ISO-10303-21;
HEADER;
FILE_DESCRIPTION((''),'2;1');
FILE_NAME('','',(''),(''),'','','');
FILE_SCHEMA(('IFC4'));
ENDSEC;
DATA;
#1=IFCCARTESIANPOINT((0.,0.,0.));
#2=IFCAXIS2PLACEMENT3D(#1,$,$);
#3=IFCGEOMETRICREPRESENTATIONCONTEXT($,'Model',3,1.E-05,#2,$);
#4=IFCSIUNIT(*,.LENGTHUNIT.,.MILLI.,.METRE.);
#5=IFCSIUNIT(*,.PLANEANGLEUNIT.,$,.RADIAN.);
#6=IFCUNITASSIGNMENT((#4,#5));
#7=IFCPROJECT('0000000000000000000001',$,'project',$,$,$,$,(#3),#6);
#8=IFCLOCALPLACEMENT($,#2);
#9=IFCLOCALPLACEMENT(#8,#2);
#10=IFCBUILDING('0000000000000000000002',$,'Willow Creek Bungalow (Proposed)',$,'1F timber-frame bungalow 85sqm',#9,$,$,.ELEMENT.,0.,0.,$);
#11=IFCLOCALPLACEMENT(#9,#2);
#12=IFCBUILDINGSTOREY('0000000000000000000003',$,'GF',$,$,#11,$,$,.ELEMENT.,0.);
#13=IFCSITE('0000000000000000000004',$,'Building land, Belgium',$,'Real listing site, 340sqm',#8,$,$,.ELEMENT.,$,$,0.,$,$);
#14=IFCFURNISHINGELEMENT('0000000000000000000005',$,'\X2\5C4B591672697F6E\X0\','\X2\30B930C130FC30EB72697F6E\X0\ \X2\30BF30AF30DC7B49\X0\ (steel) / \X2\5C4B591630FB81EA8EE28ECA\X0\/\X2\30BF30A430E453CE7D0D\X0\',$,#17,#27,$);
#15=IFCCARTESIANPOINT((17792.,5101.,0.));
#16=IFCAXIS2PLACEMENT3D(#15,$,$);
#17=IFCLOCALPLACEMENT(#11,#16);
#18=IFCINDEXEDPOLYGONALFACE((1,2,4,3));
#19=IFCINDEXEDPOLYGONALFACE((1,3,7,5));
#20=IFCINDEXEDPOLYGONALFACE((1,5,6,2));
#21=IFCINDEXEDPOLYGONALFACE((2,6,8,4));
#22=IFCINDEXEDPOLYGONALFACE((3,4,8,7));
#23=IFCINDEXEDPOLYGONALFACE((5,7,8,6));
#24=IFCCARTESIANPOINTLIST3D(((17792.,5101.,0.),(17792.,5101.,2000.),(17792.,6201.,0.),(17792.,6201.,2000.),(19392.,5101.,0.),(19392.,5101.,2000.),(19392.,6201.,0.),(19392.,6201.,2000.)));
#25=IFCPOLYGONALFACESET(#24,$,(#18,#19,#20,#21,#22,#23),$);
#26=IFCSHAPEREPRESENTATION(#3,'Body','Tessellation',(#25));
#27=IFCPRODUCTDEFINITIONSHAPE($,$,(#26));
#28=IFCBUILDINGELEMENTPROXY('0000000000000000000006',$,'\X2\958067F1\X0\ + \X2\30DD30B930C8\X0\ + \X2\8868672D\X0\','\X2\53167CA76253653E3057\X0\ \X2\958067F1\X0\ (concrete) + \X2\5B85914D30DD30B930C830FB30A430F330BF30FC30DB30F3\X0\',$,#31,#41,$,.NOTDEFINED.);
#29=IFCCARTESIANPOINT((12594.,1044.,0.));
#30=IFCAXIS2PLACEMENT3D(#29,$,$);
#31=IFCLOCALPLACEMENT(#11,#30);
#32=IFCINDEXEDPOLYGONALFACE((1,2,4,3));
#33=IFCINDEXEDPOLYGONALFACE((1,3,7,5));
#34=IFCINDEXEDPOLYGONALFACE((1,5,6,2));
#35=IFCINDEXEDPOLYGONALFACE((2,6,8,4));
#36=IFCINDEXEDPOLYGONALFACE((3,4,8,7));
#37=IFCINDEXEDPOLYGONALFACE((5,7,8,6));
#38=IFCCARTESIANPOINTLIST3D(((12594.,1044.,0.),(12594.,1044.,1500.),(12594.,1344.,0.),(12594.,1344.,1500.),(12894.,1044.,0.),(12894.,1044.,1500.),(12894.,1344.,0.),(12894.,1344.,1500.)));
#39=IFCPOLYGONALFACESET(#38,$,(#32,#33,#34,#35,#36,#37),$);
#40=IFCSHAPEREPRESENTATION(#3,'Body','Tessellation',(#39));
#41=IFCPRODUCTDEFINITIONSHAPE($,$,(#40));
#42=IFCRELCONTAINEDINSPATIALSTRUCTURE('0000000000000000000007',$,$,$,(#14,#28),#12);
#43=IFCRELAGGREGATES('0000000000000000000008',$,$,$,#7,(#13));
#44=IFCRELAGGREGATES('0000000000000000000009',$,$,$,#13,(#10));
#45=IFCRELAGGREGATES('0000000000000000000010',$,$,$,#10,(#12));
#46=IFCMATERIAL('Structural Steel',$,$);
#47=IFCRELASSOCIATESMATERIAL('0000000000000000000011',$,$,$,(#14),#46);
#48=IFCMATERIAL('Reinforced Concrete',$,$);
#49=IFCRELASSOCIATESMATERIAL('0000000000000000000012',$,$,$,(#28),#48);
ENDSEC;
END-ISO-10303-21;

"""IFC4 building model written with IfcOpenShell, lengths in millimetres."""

from ifc_helpers import new_model, si_unit, frame, frame_2d, origin, place, context, project, spatial, rectangle, extrude, material, element, save


model = new_model("IFC4")

# Units and contexts
model_context = context("Model", 3, precision=1e-05, world=origin())
ifc_project = project(units=[si_unit("LENGTHUNIT", "METRE", prefix="MILLI"), si_unit("PLANEANGLEUNIT", "RADIAN")], contexts=[model_context])

# Site, building, storey
site_placement = place(None, origin())
site = spatial("IfcSite", under=ifc_project, at=site_placement, Name="Building land, Belgium", ObjectType="Real listing site, 340sqm", CompositionType="ELEMENT", RefElevation=0.0)
building_placement = place(site_placement, origin())
building = spatial("IfcBuilding", under=site, at=building_placement, Name="Willow Creek Bungalow (Proposed)", ObjectType="1F timber-frame bungalow 85sqm", CompositionType="ELEMENT", ElevationOfRefHeight=0.0, ElevationOfTerrain=0.0)
storey_placement = place(building_placement, origin())
storey = spatial("IfcBuildingStorey", under=building, at=storey_placement, Name="GF", CompositionType="ELEMENT", Elevation=0.0)

# Shared definitions
ifc_material_1 = material(Name="Reinforced Concrete")

# Shared definitions
ifc_material_2 = material(Name="Structural Steel")

# Furnishing element
furnishing_1_placement = place(storey_placement, frame((17792.0, 5101.0, 0.0)))
element("IfcFurnishingElement", 1, at=furnishing_1_placement, inside=storey, material=ifc_material_2, Name="屋外物置", Description="スチール物置 タクボ等 (steel) / 屋外・自転車/タイヤ収納", context=model_context, shape_type="SweptSolid", body=[
    extrude(rectangle(XDim=1600.0, YDim=1100.0, at=frame_2d((800.0, 550.0))), frame((17792.0, 5101.0, 0.0)), (0.0, 0.0, 1.0), 2000.0),
])

# Building element proxy
proxy_placement = place(storey_placement, frame((12594.0, 1044.0, 0.0)))
element("IfcBuildingElementProxy", 2, at=proxy_placement, inside=storey, material=ifc_material_1, Name="門柱 + ポスト + 表札", Description="化粧打放し 門柱 (concrete) + 宅配ポスト・インターホン", PredefinedType="NOTDEFINED", context=model_context, shape_type="SweptSolid", body=[
    extrude(rectangle(XDim=300.0, YDim=300.0, at=frame_2d((150.0, 150.0))), frame((12594.0, 1044.0, 0.0)), (0.0, 0.0, 1.0), 1500.0),
])

save(model, "model.ifc")
